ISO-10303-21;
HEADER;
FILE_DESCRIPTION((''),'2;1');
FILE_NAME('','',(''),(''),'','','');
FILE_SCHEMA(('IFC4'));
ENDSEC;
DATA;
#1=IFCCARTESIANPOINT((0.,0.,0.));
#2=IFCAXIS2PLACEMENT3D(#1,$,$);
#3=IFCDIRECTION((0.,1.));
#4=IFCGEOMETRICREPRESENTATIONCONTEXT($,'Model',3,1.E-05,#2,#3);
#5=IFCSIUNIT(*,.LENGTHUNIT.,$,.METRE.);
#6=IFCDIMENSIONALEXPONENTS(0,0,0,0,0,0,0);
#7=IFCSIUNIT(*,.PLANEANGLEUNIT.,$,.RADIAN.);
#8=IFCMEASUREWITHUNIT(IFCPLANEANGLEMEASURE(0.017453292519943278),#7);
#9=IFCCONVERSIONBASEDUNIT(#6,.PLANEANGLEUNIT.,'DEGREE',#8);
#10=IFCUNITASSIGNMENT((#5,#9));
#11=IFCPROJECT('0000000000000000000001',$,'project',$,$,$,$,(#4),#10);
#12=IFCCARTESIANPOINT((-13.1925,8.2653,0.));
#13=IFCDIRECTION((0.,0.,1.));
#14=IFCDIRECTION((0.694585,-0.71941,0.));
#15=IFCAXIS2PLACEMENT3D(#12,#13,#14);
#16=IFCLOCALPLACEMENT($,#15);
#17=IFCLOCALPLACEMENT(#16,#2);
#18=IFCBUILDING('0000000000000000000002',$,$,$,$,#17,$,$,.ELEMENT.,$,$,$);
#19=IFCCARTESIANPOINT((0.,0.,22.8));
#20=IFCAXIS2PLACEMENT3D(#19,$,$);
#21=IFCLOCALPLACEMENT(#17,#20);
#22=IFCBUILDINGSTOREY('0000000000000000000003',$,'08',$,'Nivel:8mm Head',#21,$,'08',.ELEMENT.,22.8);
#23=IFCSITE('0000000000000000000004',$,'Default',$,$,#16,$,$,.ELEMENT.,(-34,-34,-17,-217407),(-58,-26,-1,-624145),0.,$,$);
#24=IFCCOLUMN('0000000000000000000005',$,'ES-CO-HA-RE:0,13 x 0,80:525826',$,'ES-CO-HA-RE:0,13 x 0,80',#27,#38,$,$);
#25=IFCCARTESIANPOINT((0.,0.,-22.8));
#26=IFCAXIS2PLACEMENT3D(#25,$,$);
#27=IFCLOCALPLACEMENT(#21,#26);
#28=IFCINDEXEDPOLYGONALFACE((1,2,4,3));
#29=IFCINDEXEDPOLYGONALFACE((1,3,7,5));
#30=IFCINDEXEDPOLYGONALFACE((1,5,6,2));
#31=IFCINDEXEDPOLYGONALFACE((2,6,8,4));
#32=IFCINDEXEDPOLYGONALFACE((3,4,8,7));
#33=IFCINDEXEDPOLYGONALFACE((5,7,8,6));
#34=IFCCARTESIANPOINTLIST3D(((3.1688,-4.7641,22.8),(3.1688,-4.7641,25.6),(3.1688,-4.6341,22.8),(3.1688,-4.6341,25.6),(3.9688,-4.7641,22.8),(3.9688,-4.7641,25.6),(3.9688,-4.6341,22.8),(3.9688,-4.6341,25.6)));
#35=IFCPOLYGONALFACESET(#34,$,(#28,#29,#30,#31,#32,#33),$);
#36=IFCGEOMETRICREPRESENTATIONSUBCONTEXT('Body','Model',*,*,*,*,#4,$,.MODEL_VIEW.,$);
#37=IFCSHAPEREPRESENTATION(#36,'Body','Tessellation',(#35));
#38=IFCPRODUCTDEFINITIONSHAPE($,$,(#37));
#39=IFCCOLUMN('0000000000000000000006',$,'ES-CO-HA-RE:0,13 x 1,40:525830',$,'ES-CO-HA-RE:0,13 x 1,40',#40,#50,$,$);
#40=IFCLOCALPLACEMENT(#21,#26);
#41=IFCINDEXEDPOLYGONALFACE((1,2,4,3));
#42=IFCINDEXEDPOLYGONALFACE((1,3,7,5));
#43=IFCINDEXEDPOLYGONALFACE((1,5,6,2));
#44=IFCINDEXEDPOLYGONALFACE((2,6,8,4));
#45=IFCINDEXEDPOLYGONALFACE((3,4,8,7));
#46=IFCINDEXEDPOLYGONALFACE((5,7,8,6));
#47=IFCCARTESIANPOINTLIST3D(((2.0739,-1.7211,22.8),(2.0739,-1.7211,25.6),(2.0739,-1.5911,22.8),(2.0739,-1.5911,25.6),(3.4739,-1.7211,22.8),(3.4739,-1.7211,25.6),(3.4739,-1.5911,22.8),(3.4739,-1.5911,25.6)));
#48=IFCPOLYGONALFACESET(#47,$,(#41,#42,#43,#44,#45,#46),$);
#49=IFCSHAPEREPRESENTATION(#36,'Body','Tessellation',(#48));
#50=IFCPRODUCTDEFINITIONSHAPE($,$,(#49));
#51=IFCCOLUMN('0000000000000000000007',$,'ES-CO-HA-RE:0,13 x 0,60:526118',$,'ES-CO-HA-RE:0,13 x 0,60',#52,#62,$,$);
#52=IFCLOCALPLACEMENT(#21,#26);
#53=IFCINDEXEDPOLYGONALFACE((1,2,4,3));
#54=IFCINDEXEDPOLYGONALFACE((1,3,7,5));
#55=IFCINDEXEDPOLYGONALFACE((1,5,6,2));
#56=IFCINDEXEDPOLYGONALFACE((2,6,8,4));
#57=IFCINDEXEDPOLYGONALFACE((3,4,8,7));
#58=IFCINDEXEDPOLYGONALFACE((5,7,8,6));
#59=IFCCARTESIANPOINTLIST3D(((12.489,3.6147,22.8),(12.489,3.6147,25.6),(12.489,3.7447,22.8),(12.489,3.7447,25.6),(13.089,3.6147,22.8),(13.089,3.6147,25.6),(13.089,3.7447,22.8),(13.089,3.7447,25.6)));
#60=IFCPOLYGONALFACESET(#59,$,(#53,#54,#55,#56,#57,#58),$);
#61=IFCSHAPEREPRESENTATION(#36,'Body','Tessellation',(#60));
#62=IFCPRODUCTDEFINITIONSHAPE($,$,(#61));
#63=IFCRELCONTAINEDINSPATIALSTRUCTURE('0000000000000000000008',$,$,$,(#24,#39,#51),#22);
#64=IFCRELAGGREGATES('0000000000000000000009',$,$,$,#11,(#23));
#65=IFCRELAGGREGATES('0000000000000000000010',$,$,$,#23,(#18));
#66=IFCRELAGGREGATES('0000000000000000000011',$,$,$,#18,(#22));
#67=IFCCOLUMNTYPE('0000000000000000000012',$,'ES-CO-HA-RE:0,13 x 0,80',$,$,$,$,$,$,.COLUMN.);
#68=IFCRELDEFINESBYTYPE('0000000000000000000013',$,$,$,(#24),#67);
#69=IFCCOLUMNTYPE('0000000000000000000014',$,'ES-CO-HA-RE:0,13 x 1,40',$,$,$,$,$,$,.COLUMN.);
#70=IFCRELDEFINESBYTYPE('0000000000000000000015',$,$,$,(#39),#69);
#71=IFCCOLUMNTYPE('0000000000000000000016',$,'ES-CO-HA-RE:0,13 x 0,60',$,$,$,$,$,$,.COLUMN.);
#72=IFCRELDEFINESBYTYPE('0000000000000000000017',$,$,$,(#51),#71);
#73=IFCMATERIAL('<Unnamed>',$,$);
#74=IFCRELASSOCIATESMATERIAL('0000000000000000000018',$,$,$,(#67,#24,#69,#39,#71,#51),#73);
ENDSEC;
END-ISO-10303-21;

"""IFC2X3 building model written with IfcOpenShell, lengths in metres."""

from ifc_helpers import new_model, entity, si_unit, converted_unit, direction, frame, frame_2d, origin, place, context, subcontext, project, spatial, rectangle, extrude, source, transform, mapped, material, type_object, type_shapes, element, save


model = new_model("IFC2X3")

# Units and contexts
model_context = context("Model", 3, precision=1e-05, world=origin(), true_north=direction((0.0, 1.0)))
body_context = subcontext(model_context, "Body", "Model", "MODEL_VIEW")
ifc_project = project(units=[si_unit("LENGTHUNIT", "METRE"), converted_unit("PLANEANGLEUNIT", "DEGREE", entity("IfcPlaneAngleMeasure", 0.017453292519943278), si_unit("PLANEANGLEUNIT", "RADIAN"), dimensions=[0, 0, 0, 0, 0, 0, 0])], contexts=[model_context])

# Site, building, storey
site_placement = place(None, frame((-13.1925, 8.2653, 0.0), z_axis=(0.0, 0.0, 1.0), x_axis=(0.694585, -0.71941, 0.0)))
site = spatial("IfcSite", under=ifc_project, at=site_placement, Name="Default", CompositionType="ELEMENT", RefLatitude=(-34, -34, -17, -217407), RefLongitude=(-58, -26, -1, -624145), RefElevation=0.0)
building_placement = place(site_placement, origin())
building = spatial("IfcBuilding", under=site, at=building_placement, CompositionType="ELEMENT")
storey_placement = place(building_placement, frame((0.0, 0.0, 22.8)))
storey = spatial("IfcBuildingStorey", under=building, at=storey_placement, Name="08", ObjectType="Nivel:8mm Head", LongName="08", CompositionType="ELEMENT", Elevation=22.8)

# Columns
ifc_material_1 = material(Name="<Unnamed>")
column_type_1 = type_object("IfcColumnType", Name="ES-CO-HA-RE:0,13 x 0,80", PredefinedType="COLUMN", material=ifc_material_1)
shared_shape_1 = source(origin(), body_context, "Body", "SweptSolid", [
    extrude(rectangle(XDim=0.8, YDim=0.13, at=frame_2d((0.0, 0.0), x_axis=(1.0, 0.0))), frame((3.5688, -4.6991, 22.8), z_axis=(0.0, 0.0, 1.0), x_axis=(-1.0, 0.0, 0.0)), (0.0, 0.0, 1.0), 2.8),
])
type_shapes(column_type_1, [shared_shape_1])
column_1_placement = place(storey_placement, frame((0.0, 0.0, -22.8)))
element("IfcColumn", 1, at=column_1_placement, inside=storey, type_object=column_type_1, material=ifc_material_1, Name="ES-CO-HA-RE:0,13 x 0,80:525826", ObjectType="ES-CO-HA-RE:0,13 x 0,80", context=body_context, shape_type="MappedRepresentation", body=[
    mapped(shared_shape_1, transform((0.0, 0.0, 0.0), scale=1.0)),
])
column_type_2 = type_object("IfcColumnType", Name="ES-CO-HA-RE:0,13 x 1,40", PredefinedType="COLUMN", material=ifc_material_1)
shared_shape_2 = source(origin(), body_context, "Body", "SweptSolid", [
    extrude(rectangle(XDim=1.4, YDim=0.13, at=frame_2d((0.0, 0.0), x_axis=(1.0, 0.0))), frame((2.7739, -1.6561, 22.8), z_axis=(0.0, 0.0, 1.0), x_axis=(-1.0, 0.0, 0.0)), (0.0, 0.0, 1.0), 2.8),
])
type_shapes(column_type_2, [shared_shape_2])
column_2_placement = place(storey_placement, frame((0.0, 0.0, -22.8)))
element("IfcColumn", 2, at=column_2_placement, inside=storey, type_object=column_type_2, material=ifc_material_1, Name="ES-CO-HA-RE:0,13 x 1,40:525830", ObjectType="ES-CO-HA-RE:0,13 x 1,40", context=body_context, shape_type="MappedRepresentation", body=[
    mapped(shared_shape_2, transform((0.0, 0.0, 0.0), scale=1.0)),
])
column_type_3 = type_object("IfcColumnType", Name="ES-CO-HA-RE:0,13 x 0,60", PredefinedType="COLUMN", material=ifc_material_1)
shared_shape_3 = source(origin(), body_context, "Body", "SweptSolid", [
    extrude(rectangle(XDim=0.6, YDim=0.13, at=frame_2d((0.0, 0.0), x_axis=(1.0, 0.0))), frame((12.789, 3.6797, 22.8), z_axis=(0.0, 0.0, 1.0), x_axis=(-1.0, 0.0, 0.0)), (0.0, 0.0, 1.0), 2.8),
])
type_shapes(column_type_3, [shared_shape_3])
column_3_placement = place(storey_placement, frame((0.0, 0.0, -22.8)))
element("IfcColumn", 3, at=column_3_placement, inside=storey, type_object=column_type_3, material=ifc_material_1, Name="ES-CO-HA-RE:0,13 x 0,60:526118", ObjectType="ES-CO-HA-RE:0,13 x 0,60", context=body_context, shape_type="MappedRepresentation", body=[
    mapped(shared_shape_3, transform((0.0, 0.0, 0.0), scale=1.0)),
])

save(model, "model.ifc")
